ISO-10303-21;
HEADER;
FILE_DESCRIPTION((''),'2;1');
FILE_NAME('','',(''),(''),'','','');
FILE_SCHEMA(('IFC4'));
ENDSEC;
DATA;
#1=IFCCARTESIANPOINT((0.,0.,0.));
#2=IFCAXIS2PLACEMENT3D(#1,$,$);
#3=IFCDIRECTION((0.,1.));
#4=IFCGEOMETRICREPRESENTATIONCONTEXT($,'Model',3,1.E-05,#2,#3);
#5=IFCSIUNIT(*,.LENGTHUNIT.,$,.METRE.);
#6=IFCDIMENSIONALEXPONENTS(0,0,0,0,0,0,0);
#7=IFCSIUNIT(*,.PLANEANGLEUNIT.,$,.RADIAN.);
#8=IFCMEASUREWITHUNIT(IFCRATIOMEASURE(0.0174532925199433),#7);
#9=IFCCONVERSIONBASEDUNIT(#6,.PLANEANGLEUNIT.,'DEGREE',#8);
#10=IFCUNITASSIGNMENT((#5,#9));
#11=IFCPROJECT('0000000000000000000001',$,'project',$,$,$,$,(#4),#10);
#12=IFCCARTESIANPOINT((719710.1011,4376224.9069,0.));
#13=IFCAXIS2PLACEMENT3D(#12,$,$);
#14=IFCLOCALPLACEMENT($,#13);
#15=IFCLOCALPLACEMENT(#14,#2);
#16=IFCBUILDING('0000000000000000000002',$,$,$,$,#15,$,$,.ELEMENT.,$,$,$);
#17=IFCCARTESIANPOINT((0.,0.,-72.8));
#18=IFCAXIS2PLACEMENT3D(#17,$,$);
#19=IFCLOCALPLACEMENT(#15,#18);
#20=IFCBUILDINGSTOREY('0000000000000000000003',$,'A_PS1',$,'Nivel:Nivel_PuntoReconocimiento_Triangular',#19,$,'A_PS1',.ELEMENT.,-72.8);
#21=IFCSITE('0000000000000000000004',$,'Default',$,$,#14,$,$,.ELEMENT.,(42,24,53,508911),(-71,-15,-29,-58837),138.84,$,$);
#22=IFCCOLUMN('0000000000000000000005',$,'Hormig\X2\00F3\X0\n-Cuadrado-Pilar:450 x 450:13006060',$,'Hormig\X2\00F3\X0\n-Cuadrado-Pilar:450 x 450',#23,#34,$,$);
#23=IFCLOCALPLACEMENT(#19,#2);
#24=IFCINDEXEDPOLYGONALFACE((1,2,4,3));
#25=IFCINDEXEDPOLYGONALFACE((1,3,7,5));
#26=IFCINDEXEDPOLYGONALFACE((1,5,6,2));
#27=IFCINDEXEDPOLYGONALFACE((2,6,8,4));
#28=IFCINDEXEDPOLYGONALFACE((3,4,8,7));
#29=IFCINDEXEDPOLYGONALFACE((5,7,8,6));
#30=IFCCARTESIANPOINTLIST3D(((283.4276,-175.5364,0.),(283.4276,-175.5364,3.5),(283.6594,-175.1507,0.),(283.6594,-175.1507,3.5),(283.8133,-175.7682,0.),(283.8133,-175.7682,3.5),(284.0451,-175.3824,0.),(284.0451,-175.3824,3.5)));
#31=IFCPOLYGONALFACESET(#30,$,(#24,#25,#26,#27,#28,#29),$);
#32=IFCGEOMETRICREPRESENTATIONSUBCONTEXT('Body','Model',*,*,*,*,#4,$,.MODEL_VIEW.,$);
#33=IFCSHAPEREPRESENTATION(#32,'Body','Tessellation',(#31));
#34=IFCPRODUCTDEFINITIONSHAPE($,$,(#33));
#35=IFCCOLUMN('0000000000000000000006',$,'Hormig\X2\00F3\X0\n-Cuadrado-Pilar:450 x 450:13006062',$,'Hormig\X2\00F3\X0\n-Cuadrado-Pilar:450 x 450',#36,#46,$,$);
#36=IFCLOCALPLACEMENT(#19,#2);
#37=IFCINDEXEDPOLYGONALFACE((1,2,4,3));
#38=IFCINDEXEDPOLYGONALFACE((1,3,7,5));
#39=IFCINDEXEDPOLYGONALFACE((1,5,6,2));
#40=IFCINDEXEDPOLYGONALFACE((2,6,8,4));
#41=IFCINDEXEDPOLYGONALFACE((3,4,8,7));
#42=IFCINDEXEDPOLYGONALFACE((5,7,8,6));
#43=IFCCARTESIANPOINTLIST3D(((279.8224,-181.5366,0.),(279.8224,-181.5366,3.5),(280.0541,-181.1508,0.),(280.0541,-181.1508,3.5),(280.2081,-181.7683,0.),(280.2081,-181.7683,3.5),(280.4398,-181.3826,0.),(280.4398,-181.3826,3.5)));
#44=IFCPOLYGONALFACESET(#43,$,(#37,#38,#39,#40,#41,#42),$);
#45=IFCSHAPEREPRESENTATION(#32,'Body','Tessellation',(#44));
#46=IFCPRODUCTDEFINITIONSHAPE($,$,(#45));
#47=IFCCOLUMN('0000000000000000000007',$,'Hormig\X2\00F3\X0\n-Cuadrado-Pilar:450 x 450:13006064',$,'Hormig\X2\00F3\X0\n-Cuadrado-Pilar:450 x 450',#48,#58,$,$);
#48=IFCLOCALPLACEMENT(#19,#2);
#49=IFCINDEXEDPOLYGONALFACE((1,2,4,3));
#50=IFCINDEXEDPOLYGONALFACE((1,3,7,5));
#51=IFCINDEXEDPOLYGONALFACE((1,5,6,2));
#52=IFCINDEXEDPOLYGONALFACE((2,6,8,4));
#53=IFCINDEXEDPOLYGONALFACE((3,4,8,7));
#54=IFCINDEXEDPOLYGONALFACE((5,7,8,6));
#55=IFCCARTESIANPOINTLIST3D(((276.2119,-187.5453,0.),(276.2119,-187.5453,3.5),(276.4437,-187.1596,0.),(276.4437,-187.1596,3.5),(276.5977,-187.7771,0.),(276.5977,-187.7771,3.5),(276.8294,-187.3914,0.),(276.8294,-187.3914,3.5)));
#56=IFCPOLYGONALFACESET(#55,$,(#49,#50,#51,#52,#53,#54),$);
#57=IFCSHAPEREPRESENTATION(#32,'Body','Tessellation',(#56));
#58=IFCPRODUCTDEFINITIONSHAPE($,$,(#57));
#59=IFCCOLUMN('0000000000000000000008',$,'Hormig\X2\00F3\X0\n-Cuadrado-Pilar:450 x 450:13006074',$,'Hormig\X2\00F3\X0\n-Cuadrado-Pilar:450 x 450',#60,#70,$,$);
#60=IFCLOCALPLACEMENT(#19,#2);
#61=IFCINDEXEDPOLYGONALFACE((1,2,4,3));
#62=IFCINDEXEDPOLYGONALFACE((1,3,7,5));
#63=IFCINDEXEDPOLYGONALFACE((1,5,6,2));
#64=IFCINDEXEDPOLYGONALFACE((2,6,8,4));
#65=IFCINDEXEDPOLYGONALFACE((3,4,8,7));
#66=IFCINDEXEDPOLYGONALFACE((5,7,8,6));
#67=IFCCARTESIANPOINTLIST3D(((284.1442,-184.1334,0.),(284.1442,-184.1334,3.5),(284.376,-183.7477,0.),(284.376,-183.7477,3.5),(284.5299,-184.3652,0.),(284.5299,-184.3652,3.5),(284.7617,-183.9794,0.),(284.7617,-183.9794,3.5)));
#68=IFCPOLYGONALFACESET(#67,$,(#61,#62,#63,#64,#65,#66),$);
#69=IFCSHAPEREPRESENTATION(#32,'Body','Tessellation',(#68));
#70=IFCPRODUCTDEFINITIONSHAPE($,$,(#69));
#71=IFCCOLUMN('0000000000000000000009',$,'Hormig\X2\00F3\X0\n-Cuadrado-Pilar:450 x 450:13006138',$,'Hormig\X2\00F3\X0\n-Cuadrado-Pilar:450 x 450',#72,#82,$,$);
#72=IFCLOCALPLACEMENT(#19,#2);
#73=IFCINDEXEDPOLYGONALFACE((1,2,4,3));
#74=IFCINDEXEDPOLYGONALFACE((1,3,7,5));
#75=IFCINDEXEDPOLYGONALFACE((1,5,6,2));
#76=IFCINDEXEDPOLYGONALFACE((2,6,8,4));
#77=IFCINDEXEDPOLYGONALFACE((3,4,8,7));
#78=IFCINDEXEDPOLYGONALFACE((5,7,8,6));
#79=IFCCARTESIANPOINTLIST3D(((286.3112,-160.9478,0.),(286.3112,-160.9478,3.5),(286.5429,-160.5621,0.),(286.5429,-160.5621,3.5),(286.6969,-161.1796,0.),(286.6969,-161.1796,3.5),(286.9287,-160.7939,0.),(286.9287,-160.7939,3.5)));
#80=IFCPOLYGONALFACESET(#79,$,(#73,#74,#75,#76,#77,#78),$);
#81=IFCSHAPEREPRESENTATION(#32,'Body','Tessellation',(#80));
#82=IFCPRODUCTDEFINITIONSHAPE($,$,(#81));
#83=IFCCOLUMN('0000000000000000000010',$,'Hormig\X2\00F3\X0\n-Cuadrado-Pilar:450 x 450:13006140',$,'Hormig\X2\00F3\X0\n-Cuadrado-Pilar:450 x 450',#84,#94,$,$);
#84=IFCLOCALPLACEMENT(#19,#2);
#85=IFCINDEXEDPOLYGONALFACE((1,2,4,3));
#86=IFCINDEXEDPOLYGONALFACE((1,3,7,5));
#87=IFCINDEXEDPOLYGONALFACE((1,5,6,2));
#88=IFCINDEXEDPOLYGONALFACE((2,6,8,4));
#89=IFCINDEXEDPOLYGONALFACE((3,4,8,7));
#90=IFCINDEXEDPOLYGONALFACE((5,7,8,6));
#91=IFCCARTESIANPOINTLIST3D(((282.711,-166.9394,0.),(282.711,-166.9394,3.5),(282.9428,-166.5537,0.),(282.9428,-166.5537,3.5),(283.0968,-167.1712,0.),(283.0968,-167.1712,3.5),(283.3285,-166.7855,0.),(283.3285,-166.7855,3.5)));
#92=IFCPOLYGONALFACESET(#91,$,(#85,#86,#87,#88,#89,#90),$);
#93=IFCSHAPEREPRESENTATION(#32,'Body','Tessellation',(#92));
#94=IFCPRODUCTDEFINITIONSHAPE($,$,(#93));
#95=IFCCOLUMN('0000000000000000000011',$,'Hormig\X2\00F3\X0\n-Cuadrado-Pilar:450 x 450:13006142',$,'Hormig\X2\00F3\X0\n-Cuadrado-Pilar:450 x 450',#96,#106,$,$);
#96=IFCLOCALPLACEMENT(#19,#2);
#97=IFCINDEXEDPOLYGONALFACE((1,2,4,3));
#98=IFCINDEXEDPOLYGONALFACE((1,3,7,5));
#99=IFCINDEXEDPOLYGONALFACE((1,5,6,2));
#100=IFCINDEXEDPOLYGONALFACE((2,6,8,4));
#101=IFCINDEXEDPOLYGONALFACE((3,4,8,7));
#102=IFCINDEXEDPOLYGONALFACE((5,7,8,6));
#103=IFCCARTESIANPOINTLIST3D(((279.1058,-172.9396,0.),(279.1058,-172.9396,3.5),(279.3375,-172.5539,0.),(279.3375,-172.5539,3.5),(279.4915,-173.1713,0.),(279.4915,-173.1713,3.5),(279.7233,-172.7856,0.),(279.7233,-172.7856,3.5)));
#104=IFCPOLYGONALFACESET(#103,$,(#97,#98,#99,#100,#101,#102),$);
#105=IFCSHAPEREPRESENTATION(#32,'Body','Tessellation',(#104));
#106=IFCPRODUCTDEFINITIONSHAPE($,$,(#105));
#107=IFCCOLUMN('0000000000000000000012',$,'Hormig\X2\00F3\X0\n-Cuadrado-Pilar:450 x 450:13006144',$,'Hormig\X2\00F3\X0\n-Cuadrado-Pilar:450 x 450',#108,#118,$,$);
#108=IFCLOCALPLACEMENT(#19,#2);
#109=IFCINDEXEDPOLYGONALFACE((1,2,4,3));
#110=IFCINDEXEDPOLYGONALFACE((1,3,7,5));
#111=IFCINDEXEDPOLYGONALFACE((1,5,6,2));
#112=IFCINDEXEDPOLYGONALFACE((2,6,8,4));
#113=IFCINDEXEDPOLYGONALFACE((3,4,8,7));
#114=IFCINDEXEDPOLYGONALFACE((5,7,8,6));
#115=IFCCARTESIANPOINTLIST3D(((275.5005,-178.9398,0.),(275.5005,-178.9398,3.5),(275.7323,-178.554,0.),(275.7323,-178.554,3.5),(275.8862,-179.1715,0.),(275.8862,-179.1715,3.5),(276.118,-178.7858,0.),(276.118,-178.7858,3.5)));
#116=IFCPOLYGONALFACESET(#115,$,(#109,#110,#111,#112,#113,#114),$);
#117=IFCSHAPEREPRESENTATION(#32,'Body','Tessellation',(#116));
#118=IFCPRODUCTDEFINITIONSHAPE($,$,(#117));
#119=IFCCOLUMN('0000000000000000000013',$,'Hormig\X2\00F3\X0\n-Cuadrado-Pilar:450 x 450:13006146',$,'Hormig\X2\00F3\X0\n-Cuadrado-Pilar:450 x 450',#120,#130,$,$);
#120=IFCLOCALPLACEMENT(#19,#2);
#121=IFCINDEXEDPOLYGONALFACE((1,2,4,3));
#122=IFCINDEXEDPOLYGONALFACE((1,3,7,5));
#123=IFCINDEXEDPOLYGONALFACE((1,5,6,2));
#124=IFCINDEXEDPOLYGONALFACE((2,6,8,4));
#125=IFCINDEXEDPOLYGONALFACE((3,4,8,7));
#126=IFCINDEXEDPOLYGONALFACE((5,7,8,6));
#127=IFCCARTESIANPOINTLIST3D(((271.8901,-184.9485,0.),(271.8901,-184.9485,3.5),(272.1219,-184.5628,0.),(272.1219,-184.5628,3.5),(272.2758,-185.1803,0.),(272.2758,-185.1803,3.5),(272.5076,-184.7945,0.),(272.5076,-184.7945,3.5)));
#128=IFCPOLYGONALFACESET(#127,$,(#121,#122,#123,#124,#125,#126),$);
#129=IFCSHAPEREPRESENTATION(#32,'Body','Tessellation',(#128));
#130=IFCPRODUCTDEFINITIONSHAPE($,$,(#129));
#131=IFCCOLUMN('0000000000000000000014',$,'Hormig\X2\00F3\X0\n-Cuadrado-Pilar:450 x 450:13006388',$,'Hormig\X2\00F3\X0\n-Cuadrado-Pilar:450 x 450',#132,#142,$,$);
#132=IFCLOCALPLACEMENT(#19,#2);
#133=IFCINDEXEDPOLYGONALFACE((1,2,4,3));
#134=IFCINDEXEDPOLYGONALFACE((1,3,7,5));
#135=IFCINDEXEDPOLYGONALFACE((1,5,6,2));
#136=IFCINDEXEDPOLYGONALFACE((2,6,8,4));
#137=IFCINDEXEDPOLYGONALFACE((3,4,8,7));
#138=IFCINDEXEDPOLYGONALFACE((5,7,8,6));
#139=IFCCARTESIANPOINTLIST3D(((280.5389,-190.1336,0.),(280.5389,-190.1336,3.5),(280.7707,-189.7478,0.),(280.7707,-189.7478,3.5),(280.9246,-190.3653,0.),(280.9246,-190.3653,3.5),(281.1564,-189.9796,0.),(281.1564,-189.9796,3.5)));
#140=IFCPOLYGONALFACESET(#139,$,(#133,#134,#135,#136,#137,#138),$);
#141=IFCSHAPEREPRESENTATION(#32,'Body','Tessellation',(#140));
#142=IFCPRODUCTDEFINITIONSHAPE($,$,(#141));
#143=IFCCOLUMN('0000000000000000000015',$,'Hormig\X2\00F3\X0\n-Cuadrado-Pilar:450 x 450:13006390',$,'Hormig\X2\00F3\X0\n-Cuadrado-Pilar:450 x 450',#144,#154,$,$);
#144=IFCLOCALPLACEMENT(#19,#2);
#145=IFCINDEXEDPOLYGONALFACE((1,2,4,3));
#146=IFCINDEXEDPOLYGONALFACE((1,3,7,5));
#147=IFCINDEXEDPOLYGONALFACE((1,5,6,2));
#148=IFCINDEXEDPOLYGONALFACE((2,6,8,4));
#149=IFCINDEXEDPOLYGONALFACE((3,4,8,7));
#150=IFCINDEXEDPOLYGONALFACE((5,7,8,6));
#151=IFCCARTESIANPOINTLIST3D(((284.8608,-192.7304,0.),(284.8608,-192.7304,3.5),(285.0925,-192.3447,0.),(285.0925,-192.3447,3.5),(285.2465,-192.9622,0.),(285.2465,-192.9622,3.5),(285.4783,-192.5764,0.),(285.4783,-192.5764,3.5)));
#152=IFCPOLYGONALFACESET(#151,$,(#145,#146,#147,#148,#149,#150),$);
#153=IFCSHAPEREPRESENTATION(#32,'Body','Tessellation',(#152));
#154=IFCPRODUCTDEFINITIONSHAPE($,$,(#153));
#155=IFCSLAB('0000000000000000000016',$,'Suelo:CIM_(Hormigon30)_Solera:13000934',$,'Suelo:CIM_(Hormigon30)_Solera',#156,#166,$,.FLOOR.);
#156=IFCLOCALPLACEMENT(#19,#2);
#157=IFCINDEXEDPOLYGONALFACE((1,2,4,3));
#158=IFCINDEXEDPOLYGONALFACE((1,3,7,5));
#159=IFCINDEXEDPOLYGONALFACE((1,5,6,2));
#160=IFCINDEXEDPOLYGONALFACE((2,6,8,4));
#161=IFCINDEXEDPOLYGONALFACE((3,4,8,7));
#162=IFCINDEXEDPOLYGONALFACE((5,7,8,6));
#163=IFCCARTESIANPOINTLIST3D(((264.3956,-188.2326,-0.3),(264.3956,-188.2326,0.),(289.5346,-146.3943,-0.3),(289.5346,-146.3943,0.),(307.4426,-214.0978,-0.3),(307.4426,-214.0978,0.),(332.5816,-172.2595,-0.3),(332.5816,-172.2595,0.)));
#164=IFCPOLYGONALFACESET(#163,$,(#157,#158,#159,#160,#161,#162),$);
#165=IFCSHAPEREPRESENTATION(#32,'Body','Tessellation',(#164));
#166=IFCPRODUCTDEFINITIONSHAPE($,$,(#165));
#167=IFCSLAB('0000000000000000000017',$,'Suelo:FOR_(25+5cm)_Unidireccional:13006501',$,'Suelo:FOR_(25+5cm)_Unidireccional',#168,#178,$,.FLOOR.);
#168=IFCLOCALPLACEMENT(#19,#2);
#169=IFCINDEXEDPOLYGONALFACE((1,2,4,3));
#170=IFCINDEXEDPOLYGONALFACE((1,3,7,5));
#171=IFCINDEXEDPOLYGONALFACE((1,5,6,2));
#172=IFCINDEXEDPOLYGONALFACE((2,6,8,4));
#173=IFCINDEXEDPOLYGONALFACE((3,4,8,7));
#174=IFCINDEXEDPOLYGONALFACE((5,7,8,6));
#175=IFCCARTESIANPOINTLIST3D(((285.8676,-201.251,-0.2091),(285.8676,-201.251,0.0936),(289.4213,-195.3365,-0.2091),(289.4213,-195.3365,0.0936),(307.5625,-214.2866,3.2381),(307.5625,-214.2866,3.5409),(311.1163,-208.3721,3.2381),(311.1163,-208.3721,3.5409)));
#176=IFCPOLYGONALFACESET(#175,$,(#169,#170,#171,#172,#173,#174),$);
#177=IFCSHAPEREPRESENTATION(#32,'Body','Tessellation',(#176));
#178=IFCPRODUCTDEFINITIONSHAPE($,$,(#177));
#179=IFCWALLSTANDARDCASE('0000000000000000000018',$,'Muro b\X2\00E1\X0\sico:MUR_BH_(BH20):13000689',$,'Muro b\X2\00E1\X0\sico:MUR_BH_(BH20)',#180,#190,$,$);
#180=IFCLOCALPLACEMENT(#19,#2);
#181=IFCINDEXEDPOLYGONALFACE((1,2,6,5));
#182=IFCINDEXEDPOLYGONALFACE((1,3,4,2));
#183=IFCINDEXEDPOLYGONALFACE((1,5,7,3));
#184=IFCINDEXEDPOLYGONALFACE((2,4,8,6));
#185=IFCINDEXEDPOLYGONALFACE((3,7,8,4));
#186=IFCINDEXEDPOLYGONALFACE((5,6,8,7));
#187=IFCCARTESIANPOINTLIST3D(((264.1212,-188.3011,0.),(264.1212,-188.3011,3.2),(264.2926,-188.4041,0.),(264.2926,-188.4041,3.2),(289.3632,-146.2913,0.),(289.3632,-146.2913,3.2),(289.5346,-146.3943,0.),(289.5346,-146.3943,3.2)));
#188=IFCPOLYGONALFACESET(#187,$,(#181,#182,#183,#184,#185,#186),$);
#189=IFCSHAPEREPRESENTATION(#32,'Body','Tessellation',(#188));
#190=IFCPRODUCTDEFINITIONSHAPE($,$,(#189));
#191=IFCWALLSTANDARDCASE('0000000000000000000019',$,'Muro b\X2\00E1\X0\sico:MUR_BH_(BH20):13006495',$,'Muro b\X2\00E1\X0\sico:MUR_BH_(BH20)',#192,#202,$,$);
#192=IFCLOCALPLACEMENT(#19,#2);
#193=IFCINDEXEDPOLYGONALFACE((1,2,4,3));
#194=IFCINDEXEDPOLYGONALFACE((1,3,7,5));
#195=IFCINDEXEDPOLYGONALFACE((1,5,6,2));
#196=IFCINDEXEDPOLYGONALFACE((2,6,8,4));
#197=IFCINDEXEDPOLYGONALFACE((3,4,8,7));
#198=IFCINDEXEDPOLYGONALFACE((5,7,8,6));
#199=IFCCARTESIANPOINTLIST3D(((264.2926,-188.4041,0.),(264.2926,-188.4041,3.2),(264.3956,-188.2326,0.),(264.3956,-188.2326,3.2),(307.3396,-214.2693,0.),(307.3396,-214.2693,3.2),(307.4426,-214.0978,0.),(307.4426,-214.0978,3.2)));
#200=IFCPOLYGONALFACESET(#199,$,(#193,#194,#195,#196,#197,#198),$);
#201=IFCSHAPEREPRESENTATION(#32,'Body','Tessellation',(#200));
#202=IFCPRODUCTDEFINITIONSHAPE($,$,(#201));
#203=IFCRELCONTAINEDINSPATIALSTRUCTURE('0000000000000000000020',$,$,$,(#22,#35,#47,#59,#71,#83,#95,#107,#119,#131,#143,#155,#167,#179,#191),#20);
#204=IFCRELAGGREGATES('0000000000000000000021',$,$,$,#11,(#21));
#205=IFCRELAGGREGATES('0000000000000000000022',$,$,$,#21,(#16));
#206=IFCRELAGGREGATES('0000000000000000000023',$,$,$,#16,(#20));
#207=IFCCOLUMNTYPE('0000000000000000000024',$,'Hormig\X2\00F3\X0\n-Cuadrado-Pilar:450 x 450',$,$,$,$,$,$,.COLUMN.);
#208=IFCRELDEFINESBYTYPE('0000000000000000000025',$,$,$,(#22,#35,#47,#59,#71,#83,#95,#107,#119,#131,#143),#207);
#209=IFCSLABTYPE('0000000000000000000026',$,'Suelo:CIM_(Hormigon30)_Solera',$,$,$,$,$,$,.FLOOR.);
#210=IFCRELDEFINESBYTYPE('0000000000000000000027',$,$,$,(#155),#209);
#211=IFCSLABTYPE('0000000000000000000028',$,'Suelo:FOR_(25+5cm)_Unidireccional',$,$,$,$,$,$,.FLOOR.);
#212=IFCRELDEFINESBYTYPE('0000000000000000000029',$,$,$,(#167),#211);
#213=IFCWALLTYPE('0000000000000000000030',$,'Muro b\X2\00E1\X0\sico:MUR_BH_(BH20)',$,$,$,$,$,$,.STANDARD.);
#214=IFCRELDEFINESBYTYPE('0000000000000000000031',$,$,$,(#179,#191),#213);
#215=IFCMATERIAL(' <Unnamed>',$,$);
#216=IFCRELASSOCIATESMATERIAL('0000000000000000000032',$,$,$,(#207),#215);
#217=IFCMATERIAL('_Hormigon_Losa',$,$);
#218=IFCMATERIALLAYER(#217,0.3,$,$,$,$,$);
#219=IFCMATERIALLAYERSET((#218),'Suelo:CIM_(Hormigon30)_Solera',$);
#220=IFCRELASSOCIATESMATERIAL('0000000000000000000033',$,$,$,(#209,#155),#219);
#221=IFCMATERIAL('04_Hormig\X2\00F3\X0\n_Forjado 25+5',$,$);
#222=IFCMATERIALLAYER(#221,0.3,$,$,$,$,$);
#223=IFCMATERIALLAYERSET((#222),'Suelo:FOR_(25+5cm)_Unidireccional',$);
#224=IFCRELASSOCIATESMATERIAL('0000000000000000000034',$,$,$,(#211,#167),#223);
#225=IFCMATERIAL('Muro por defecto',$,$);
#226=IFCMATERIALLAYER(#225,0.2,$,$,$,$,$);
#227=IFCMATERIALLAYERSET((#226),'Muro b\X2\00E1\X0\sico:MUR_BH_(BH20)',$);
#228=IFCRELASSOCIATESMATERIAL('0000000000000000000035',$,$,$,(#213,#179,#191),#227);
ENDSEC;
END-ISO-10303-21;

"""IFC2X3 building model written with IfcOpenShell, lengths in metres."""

from ifc_helpers import new_model, entity, si_unit, converted_unit, direction, frame, frame_2d, origin, origin_2d_with_axis, place, context, subcontext, project, spatial, rectangle, extrude, clip, halfspace, source, transform, mapped, material, layer, layer_set, layer_usage, type_object, type_shapes, element, save


model = new_model("IFC2X3")

# Units and contexts
model_context = context("Model", 3, precision=1e-05, world=origin(), true_north=direction((0.0, 1.0)))
body_context = subcontext(model_context, "Body", "Model", "MODEL_VIEW")
ifc_project = project(units=[si_unit("LENGTHUNIT", "METRE"), converted_unit("PLANEANGLEUNIT", "DEGREE", entity("IfcRatioMeasure", 0.0174532925199433), si_unit("PLANEANGLEUNIT", "RADIAN"), dimensions=[0, 0, 0, 0, 0, 0, 0])], contexts=[model_context])

# Site, building, storey
site_placement = place(None, frame((719710.1011, 4376224.9069, 0.0)))
site = spatial("IfcSite", under=ifc_project, at=site_placement, Name="Default", CompositionType="ELEMENT", RefLatitude=(42, 24, 53, 508911), RefLongitude=(-71, -15, -29, -58837), RefElevation=138.84)
building_placement = place(site_placement, origin())
building = spatial("IfcBuilding", under=site, at=building_placement, CompositionType="ELEMENT")
storey_placement = place(building_placement, frame((0.0, 0.0, -72.8)))
storey = spatial("IfcBuildingStorey", under=building, at=storey_placement, Name="A_PS1", ObjectType="Nivel:Nivel_PuntoReconocimiento_Triangular", LongName="A_PS1", CompositionType="ELEMENT", Elevation=-72.8)

# Columns
ifc_material_1 = material(Name=" <Unnamed>")
column_type = type_object("IfcColumnType", Name="Hormigón-Cuadrado-Pilar:450 x 450", PredefinedType="COLUMN", material=ifc_material_1)
shared_shape = source(origin(), body_context, "Body", "SweptSolid", [
    extrude(rectangle(XDim=0.45, YDim=0.45, at=origin_2d_with_axis()), frame((0.0, 0.0, -72.8), z_axis=(0.0, 0.0, 1.0), x_axis=(0.0, -1.0, 0.0)), (0.0, 0.0, 1.0), 3.5),
])
type_shapes(column_type, [shared_shape])
for number, where, z_axis, x_axis, name in (
    (1, (283.7364, -175.4594, 72.8), (0.0, 0.0, 1.0), (0.857167, -0.515038, 0.0), "Hormigón-Cuadrado-Pilar:450 x 450:13006060"),
    (2, (280.1311, -181.4596, 72.8), (0.0, 0.0, 1.0), (0.857167, -0.515038, 0.0), "Hormigón-Cuadrado-Pilar:450 x 450:13006062"),
    (3, (276.5207, -187.4683, 72.8), (0.0, 0.0, 1.0), (0.857167, -0.515038, 0.0), "Hormigón-Cuadrado-Pilar:450 x 450:13006064"),
    (4, (284.4529, -184.0564, 72.8), (0.0, 0.0, 1.0), (0.857167, -0.515038, 0.0), "Hormigón-Cuadrado-Pilar:450 x 450:13006074"),
    (5, (286.6199, -160.8708, 72.8), (0.0, 0.0, 1.0), (0.857167, -0.515038, 0.0), "Hormigón-Cuadrado-Pilar:450 x 450:13006138"),
    (6, (283.0198, -166.8624, 72.8), (0.0, 0.0, 1.0), (0.857167, -0.515038, 0.0), "Hormigón-Cuadrado-Pilar:450 x 450:13006140"),
    (7, (279.4145, -172.8626, 72.8), (0.0, 0.0, 1.0), (0.857167, -0.515038, 0.0), "Hormigón-Cuadrado-Pilar:450 x 450:13006142"),
    (8, (275.8093, -178.8628, 72.8), (0.0, 0.0, 1.0), (0.857167, -0.515038, 0.0), "Hormigón-Cuadrado-Pilar:450 x 450:13006144"),
    (9, (272.1988, -184.8715, 72.8), (0.0, 0.0, 1.0), (0.857167, -0.515038, 0.0), "Hormigón-Cuadrado-Pilar:450 x 450:13006146"),
    (10, (280.8477, -190.0566, 72.8), (0.0, 0.0, 1.0), (0.857167, -0.515038, 0.0), "Hormigón-Cuadrado-Pilar:450 x 450:13006388"),
    (11, (285.1695, -192.6534, 72.8), (0.0, 0.0, 1.0), (0.857167, -0.515038, 0.0), "Hormigón-Cuadrado-Pilar:450 x 450:13006390"),
):
    element("IfcColumn", number, at=place(storey_placement, frame(where, z_axis=z_axis, x_axis=x_axis)), inside=storey, type_object=column_type, Name=name, ObjectType="Hormigón-Cuadrado-Pilar:450 x 450", context=body_context, shape_type="MappedRepresentation", body=[
        mapped(shared_shape, transform((0.0, 0.0, 0.0), scale=1.0)),
    ])

# Slabs
ifc_material_2 = material(Name="_Hormigon_Losa")
ifc_layer_1 = layer(ifc_material_2, 0.3)
ifc_layer_set_1 = layer_set([ifc_layer_1], Name="Suelo:CIM_(Hormigon30)_Solera")
ifc_layer_usage_1 = layer_usage(ifc_layer_set_1, "AXIS3", "POSITIVE", 0.0)
slab_type_1 = type_object("IfcSlabType", Name="Suelo:CIM_(Hormigon30)_Solera", PredefinedType="FLOOR", material=ifc_layer_set_1)
slab_1_placement = place(storey_placement, origin())
element("IfcSlab", 12, at=slab_1_placement, inside=storey, type_object=slab_type_1, material=ifc_layer_usage_1, Name="Suelo:CIM_(Hormigon30)_Solera:13000934", ObjectType="Suelo:CIM_(Hormigon30)_Solera", PredefinedType="FLOOR", context=body_context, shape_type="SweptSolid", body=[
    extrude(rectangle(XDim=50.22, YDim=48.81, at=frame_2d((0.0, 0.0), x_axis=(1.0, 0.0))), frame((298.4886, -180.2461, 0.0), z_axis=(0.0, 0.0, -1.0), x_axis=(0.857167, -0.515038, 0.0)), (0.0, 0.0, 1.0), 0.3),
])
ifc_material_3 = material(Name="04_Hormigón_Forjado 25+5")
ifc_layer_2 = layer(ifc_material_3, 0.3)
ifc_layer_set_2 = layer_set([ifc_layer_2], Name="Suelo:FOR_(25+5cm)_Unidireccional")
ifc_layer_usage_2 = layer_usage(ifc_layer_set_2, "AXIS3", "POSITIVE", 0.0)
slab_type_2 = type_object("IfcSlabType", Name="Suelo:FOR_(25+5cm)_Unidireccional", PredefinedType="FLOOR", material=ifc_layer_set_2)
slab_2_placement = place(storey_placement, origin())
element("IfcSlab", 13, at=slab_2_placement, inside=storey, type_object=slab_type_2, material=ifc_layer_usage_2, Name="Suelo:FOR_(25+5cm)_Unidireccional:13006501", ObjectType="Suelo:FOR_(25+5cm)_Unidireccional", PredefinedType="FLOOR", context=body_context, shape_type="Clipping", body=[
    clip(clip(extrude(rectangle(XDim=25.5437, YDim=6.9, at=frame_2d((0.0, 0.0), x_axis=(1.0, 0.0))), frame((298.4919, -204.8115, 1.8172), z_axis=(0.115678, -0.069506, -0.990852), x_axis=(0.849326, -0.510326, 0.134954)), (-0.134954, 0.0, 0.990852), 0.3056), halfspace(frame((287.6187, -198.3366, -0.2091), z_axis=(0.115678, -0.069506, -0.990852), x_axis=(0.849326, -0.510326, 0.134954)), False)), halfspace(frame((287.6187, -198.3366, 0.0936), z_axis=(-0.115678, 0.069506, 0.990852), x_axis=(-0.849326, 0.510326, -0.134954)), False)),
])

# Walls
ifc_material_4 = material(Name="Muro por defecto")
ifc_layer_3 = layer(ifc_material_4, 0.2)
ifc_layer_set_3 = layer_set([ifc_layer_3], Name="Muro básico:MUR_BH_(BH20)")
ifc_layer_usage_3 = layer_usage(ifc_layer_set_3, "AXIS2", "NEGATIVE", 0.1)
wall_type = type_object("IfcWallType", Name="Muro básico:MUR_BH_(BH20)", PredefinedType="STANDARD", material=ifc_layer_set_3)
wall_1_placement = place(storey_placement, frame((264.2069, -188.3526, 0.0), z_axis=(0.0, 0.0, 1.0), x_axis=(0.515038, 0.857167, 0.0)))
element("IfcWallStandardCase", 14, at=wall_1_placement, inside=storey, type_object=wall_type, material=ifc_layer_usage_3, Name="Muro básico:MUR_BH_(BH20):13000689", ObjectType="Muro básico:MUR_BH_(BH20)", context=body_context, shape_type="SweptSolid", body=[
    extrude(rectangle(XDim=49.01, YDim=0.2, at=frame_2d((24.505, 0.0), x_axis=(-1.0, 0.0))), origin(), (0.0, 0.0, 1.0), 3.2),
])
ifc_layer_usage_4 = layer_usage(ifc_layer_set_3, "AXIS2", "NEGATIVE", 0.1)
wall_2_placement = place(storey_placement, frame((264.3441, -188.3184, 0.0), z_axis=(0.0, 0.0, 1.0), x_axis=(0.857167, -0.515038, 0.0)))
element("IfcWallStandardCase", 15, at=wall_2_placement, inside=storey, type_object=wall_type, material=ifc_layer_usage_4, Name="Muro básico:MUR_BH_(BH20):13006495", ObjectType="Muro básico:MUR_BH_(BH20)", context=body_context, shape_type="SweptSolid", body=[
    extrude(rectangle(XDim=50.22, YDim=0.2, at=frame_2d((25.11, 0.0), x_axis=(-1.0, 0.0))), origin(), (0.0, 0.0, 1.0), 3.2),
])

save(model, "model.ifc")
